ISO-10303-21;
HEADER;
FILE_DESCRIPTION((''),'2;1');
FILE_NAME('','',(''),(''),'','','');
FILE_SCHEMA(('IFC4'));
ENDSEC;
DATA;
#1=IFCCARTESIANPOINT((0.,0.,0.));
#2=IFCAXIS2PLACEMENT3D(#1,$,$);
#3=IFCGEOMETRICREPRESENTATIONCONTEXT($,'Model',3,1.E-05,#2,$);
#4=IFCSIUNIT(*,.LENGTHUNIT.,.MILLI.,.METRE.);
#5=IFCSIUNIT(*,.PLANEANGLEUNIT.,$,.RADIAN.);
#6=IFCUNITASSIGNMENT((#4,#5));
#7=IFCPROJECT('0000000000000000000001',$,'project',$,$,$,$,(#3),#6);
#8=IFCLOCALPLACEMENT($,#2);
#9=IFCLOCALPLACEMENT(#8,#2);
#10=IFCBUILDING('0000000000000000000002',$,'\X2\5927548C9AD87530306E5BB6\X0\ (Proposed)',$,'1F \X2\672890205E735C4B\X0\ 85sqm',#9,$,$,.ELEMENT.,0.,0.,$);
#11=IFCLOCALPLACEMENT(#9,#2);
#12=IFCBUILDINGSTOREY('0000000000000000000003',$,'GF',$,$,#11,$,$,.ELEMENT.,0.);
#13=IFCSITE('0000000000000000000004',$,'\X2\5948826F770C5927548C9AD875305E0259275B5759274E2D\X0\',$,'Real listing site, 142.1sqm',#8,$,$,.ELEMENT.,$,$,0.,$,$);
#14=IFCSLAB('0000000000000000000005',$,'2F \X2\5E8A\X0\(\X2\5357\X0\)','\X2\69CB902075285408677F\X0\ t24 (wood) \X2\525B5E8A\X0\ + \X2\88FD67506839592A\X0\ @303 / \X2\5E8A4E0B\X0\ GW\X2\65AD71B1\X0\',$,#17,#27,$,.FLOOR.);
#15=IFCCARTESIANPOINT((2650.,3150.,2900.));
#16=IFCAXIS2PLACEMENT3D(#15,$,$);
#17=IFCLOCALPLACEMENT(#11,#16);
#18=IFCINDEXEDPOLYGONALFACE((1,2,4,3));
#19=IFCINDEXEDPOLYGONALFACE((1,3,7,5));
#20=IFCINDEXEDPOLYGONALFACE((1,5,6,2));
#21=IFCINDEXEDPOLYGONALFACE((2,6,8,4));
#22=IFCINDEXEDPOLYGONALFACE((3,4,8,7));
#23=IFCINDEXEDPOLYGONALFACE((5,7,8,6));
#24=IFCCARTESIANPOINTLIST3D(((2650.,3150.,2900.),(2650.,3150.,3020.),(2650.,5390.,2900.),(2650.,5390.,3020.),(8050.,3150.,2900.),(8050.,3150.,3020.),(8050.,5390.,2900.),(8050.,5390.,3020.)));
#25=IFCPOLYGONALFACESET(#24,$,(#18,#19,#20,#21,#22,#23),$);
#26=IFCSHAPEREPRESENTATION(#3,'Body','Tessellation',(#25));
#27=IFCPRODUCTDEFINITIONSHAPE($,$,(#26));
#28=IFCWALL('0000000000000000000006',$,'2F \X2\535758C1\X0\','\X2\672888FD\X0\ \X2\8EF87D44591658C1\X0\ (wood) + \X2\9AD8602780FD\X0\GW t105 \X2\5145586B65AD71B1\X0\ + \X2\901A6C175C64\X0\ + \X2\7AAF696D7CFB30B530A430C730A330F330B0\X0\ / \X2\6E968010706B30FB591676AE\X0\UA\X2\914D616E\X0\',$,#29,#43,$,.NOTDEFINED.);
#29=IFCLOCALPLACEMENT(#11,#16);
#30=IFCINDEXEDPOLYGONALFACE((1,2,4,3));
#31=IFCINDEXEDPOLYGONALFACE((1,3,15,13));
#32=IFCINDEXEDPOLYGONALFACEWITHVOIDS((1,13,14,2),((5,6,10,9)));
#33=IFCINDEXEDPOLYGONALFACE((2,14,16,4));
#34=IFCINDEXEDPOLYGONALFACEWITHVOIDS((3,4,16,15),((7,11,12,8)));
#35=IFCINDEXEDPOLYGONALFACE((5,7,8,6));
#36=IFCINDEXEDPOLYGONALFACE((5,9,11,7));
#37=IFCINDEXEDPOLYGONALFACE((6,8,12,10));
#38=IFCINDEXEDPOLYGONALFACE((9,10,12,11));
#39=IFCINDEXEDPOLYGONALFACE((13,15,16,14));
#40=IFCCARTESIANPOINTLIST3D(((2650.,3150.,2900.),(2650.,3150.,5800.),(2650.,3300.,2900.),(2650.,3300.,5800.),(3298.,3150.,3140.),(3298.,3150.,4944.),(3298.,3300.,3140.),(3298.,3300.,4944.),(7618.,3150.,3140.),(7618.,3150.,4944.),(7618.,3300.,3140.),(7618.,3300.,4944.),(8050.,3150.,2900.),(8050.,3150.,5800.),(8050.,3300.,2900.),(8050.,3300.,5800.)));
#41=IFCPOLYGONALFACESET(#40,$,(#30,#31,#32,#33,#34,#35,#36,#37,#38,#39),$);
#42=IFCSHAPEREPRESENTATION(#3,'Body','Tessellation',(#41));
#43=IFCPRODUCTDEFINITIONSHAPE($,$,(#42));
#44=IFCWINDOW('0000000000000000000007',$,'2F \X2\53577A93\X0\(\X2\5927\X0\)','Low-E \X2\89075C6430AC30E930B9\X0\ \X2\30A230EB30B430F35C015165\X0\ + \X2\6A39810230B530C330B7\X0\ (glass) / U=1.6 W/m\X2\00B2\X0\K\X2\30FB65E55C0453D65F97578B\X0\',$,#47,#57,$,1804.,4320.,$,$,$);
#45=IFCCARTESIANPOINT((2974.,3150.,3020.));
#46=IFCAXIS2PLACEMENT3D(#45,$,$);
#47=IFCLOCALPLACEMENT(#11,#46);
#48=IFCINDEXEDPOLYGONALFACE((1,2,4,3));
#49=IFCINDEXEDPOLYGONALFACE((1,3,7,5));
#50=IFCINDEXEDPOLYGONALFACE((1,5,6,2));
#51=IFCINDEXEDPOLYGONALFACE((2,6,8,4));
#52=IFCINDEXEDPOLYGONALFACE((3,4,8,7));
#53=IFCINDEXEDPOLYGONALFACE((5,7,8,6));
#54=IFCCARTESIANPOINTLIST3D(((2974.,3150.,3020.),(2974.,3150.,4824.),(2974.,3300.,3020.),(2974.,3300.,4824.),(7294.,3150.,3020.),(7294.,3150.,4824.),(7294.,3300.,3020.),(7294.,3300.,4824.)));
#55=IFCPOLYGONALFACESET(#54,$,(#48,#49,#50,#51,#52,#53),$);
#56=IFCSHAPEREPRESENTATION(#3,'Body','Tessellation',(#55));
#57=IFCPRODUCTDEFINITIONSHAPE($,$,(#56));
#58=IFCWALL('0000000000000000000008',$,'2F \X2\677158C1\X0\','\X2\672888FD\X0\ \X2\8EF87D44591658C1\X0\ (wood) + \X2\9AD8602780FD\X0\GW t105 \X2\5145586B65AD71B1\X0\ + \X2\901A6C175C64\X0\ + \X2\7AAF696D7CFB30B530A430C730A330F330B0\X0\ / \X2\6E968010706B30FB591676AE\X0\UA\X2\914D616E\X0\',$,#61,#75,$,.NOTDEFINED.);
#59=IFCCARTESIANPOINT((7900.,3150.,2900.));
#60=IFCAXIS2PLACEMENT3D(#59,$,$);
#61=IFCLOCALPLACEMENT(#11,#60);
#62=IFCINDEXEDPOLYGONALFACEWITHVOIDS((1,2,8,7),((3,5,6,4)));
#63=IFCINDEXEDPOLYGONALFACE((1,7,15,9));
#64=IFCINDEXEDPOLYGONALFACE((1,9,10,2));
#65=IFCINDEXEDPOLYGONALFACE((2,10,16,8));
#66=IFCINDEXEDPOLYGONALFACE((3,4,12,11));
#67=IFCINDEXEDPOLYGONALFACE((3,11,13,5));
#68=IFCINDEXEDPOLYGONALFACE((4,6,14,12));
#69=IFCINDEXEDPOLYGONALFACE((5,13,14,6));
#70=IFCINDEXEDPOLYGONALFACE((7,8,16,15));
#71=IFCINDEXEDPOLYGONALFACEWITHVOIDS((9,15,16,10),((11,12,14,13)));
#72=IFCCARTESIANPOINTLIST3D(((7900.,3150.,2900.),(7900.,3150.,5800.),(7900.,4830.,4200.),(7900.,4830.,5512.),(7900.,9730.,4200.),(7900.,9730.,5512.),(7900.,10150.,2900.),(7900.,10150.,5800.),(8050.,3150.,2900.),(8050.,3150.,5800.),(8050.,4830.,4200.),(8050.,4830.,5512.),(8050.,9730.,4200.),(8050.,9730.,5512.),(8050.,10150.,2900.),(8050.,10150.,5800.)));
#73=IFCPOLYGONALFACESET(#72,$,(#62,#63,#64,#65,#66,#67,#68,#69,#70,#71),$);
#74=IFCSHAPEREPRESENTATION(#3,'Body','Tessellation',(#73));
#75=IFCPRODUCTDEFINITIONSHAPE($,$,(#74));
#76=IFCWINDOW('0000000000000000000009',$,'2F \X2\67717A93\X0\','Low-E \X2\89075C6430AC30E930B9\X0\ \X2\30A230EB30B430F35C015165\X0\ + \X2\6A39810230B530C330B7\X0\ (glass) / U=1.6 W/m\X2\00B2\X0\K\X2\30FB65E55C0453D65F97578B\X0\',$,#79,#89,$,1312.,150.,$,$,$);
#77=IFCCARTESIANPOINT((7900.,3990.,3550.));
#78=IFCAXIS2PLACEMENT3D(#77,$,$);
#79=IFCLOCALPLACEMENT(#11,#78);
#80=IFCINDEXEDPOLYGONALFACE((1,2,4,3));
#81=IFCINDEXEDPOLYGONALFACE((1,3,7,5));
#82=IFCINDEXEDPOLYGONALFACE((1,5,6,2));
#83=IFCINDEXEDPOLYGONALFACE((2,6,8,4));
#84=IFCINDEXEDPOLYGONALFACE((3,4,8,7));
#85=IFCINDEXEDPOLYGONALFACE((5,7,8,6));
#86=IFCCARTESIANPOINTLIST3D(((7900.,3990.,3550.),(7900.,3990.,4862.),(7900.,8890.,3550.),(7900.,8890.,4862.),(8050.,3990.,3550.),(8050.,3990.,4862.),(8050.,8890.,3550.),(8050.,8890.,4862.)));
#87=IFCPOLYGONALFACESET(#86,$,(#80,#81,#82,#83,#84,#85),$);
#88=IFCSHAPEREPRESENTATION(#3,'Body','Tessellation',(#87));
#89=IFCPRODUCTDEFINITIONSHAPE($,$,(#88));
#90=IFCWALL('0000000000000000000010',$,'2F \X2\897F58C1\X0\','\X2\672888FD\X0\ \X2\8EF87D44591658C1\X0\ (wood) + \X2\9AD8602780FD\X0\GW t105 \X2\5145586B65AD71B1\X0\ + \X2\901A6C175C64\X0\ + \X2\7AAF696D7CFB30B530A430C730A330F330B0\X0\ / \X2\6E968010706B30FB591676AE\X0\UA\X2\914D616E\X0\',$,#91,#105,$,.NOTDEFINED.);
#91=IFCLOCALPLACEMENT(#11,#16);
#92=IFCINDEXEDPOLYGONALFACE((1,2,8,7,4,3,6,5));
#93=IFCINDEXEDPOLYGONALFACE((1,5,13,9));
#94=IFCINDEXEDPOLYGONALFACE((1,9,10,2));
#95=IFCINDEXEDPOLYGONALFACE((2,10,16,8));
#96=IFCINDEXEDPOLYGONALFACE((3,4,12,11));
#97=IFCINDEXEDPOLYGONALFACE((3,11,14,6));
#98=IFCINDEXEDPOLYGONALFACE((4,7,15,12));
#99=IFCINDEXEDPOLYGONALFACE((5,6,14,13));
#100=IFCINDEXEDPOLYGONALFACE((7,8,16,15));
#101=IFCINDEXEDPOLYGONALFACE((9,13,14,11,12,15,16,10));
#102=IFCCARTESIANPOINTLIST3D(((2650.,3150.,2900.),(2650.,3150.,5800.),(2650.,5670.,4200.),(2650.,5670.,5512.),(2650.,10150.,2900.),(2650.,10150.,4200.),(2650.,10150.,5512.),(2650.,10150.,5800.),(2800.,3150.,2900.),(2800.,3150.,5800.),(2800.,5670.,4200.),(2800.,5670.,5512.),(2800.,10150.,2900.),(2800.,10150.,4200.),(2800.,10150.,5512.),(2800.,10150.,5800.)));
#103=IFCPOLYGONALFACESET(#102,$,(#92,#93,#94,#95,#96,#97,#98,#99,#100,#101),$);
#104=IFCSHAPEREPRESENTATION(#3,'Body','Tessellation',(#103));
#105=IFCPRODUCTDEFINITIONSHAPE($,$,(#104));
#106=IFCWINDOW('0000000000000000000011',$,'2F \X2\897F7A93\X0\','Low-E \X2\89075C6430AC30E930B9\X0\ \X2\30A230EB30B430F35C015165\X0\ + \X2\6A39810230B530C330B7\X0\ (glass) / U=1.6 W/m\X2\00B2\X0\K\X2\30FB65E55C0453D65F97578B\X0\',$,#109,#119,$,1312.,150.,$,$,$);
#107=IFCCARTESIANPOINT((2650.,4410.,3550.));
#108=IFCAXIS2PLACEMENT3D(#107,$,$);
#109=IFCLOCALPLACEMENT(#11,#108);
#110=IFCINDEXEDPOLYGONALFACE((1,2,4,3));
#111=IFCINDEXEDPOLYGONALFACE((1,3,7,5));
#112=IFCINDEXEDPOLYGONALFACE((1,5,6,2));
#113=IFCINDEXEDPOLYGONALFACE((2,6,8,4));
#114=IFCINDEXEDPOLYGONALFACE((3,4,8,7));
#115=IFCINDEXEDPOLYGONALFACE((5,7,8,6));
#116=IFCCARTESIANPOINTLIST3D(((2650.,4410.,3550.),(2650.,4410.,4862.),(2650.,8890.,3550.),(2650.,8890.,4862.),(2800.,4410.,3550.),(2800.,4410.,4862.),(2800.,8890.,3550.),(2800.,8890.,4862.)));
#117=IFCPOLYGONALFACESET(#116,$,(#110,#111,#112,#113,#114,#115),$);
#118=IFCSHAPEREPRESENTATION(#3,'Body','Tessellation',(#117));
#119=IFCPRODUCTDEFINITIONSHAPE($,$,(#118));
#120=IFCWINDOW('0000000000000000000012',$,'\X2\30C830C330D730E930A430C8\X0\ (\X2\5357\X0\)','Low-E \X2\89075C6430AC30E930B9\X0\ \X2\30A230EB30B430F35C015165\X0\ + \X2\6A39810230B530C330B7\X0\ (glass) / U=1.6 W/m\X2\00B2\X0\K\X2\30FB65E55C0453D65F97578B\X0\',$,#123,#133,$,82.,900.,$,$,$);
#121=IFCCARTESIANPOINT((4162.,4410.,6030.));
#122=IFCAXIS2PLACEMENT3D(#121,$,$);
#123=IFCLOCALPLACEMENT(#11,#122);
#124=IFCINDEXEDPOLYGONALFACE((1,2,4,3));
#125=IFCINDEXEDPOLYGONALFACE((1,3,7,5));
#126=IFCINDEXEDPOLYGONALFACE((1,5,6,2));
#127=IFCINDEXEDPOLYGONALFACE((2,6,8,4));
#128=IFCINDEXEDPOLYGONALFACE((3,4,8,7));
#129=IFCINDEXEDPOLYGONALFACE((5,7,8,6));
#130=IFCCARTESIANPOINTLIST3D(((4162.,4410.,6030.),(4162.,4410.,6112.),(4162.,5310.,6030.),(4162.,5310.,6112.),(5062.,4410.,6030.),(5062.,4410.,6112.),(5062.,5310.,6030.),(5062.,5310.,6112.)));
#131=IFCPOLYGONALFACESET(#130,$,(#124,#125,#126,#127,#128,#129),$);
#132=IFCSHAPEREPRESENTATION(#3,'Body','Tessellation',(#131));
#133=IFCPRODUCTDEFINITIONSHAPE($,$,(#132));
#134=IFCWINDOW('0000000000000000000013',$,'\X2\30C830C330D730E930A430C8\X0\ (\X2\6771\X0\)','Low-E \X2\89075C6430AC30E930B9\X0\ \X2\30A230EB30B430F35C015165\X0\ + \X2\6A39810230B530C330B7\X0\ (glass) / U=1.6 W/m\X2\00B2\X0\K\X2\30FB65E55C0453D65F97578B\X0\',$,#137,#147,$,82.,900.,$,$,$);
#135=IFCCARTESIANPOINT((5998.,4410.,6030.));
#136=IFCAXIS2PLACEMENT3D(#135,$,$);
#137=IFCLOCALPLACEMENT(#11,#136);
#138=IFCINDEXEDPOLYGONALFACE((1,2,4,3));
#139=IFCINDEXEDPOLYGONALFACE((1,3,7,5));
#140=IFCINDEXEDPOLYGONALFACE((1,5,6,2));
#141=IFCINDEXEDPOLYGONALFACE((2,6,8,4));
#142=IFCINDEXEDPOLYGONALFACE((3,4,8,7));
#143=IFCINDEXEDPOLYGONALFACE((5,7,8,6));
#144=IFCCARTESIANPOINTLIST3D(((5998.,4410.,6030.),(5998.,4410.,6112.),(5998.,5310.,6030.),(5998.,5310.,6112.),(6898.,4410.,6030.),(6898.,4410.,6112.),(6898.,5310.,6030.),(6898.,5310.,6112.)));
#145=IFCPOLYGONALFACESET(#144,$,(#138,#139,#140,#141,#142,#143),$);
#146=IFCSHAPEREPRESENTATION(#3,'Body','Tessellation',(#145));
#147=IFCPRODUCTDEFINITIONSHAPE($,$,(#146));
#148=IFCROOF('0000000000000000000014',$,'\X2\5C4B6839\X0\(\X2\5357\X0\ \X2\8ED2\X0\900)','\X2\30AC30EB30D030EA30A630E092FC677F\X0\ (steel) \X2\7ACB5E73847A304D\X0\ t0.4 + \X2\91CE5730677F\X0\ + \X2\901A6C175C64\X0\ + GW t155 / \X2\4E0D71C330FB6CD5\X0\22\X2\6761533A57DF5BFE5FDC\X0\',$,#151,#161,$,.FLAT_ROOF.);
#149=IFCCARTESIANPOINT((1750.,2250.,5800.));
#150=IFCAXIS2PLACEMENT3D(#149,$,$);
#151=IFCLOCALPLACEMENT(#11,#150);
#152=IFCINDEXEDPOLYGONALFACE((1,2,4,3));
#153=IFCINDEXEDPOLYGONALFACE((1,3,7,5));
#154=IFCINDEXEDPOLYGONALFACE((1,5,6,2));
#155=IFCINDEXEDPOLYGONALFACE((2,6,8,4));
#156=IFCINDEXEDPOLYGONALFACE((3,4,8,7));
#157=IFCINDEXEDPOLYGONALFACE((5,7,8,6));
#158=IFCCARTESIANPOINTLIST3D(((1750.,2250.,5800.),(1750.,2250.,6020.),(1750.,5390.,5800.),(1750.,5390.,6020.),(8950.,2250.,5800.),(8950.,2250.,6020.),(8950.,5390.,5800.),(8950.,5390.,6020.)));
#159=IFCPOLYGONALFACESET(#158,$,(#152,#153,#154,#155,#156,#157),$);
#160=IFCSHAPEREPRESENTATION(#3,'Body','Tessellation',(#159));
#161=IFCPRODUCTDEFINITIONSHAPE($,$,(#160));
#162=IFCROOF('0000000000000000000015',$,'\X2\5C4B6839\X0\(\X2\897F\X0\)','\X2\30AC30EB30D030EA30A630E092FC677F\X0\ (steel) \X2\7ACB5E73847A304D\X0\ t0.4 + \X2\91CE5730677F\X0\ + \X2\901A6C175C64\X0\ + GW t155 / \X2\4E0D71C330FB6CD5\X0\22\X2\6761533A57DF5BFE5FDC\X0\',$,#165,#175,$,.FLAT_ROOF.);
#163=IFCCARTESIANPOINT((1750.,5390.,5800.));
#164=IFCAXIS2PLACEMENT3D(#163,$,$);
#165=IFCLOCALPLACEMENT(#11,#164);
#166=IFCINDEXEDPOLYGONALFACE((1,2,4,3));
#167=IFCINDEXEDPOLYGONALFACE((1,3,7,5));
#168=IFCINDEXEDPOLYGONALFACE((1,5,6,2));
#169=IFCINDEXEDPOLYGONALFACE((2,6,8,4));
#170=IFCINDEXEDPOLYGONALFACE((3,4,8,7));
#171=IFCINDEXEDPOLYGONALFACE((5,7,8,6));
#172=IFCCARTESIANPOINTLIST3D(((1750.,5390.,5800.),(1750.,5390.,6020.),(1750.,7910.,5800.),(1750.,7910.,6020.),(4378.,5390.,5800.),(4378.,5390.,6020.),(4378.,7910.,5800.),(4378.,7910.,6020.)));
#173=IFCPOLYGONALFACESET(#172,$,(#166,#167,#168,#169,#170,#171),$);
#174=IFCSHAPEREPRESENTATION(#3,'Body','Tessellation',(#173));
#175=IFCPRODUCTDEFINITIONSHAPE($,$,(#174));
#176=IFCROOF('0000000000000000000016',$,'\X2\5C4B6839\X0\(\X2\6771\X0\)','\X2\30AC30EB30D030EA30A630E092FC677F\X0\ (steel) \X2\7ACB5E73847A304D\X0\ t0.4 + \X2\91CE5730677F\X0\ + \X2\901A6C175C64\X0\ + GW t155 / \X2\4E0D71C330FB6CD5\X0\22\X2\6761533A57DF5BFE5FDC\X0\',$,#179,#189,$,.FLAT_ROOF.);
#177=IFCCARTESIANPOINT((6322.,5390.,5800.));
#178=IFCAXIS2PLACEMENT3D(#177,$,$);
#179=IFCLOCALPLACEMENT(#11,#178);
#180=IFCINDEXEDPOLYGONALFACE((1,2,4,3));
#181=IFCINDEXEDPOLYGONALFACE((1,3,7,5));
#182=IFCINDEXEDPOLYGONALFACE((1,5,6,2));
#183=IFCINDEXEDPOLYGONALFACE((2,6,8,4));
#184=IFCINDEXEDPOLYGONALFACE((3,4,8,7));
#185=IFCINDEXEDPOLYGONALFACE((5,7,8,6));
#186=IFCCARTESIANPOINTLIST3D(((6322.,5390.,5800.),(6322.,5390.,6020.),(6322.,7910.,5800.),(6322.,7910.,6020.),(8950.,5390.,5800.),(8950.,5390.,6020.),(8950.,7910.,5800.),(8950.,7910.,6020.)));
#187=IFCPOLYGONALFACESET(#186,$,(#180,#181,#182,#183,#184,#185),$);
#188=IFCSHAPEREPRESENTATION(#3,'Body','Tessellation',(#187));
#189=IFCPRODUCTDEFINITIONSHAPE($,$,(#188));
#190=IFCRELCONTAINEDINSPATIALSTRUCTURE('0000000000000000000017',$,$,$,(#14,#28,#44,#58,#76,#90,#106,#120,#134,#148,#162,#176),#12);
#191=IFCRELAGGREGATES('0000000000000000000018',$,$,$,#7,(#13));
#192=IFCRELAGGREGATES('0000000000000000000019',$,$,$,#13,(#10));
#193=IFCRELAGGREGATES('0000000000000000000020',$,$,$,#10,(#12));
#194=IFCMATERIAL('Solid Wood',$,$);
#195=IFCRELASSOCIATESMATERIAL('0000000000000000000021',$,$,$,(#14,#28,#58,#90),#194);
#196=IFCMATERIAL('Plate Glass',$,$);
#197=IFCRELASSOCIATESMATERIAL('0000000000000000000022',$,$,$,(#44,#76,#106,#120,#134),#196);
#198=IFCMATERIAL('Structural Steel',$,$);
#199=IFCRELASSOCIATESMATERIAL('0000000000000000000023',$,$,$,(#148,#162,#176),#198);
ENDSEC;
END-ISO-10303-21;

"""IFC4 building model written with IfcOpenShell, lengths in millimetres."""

from ifc_helpers import new_model, si_unit, frame, frame_2d, origin, place, context, project, spatial, rectangle, extrude, material, element, fill, save


model = new_model("IFC4")

# Units and contexts
model_context = context("Model", 3, precision=1e-05, world=origin())
ifc_project = project(units=[si_unit("LENGTHUNIT", "METRE", prefix="MILLI"), si_unit("PLANEANGLEUNIT", "RADIAN")], contexts=[model_context])

# Site, building, storey
site_placement = place(None, origin())
site = spatial("IfcSite", under=ifc_project, at=site_placement, Name="奈良県大和高田市大字大中", ObjectType="Real listing site, 142.1sqm", CompositionType="ELEMENT", RefElevation=0.0)
building_placement = place(site_placement, origin())
building = spatial("IfcBuilding", under=site, at=building_placement, Name="大和高田の家 (Proposed)", ObjectType="1F 木造平屋 85sqm", CompositionType="ELEMENT", ElevationOfRefHeight=0.0, ElevationOfTerrain=0.0)
storey_placement = place(building_placement, origin())
storey = spatial("IfcBuildingStorey", under=building, at=storey_placement, Name="GF", CompositionType="ELEMENT", Elevation=0.0)

# Slab
ifc_material_1 = material(Name="Solid Wood")
slab_placement = place(storey_placement, frame((2650.0, 3150.0, 2900.0)))
element("IfcSlab", 1, at=slab_placement, inside=storey, material=ifc_material_1, Name="2F 床(南)", Description="構造用合板 t24 (wood) 剛床 + 製材根太 @303 / 床下 GW断熱", PredefinedType="FLOOR", context=model_context, shape_type="SweptSolid", body=[
    extrude(rectangle(XDim=5400.0, YDim=2240.0, at=frame_2d((2700.0, 1120.0))), frame((2650.0, 3150.0, 2900.0)), (0.0, 0.0, 1.0), 120.0),
])

# Walls, openings, windows
wall_1_placement = place(storey_placement, frame((2650.0, 3150.0, 2900.0)))
wall_1 = element("IfcWall", 2, at=wall_1_placement, inside=storey, material=ifc_material_1, Name="2F 南壁", Description="木製 軸組外壁 (wood) + 高性能GW t105 充填断熱 + 通気層 + 窯業系サイディング / 準耐火・外皮UA配慮", PredefinedType="NOTDEFINED", context=model_context, shape_type="SweptSolid", body=[
    extrude(rectangle(XDim=5400.0, YDim=150.0, at=frame_2d((2700.0, 75.0))), frame((2650.0, 3150.0, 2900.0)), (0.0, 0.0, 1.0), 2900.0),
])
opening_1_placement = place(storey_placement, frame((2974.0, 3150.0, 3020.0)))
opening_1 = element("IfcOpeningElement", 3, at=opening_1_placement, cuts=wall_1, PredefinedType="NOTDEFINED", context=model_context, shape_type="SweptSolid", body=[
    extrude(rectangle(XDim=4320.0, YDim=150.0, at=frame_2d((2160.0, 75.0))), frame((2974.0, 3150.0, 3020.0)), (0.0, 0.0, 1.0), 1804.0),
])
ifc_material_2 = material(Name="Plate Glass")
window_1_placement = place(storey_placement, frame((2974.0, 3150.0, 3020.0)))
window_1 = element("IfcWindow", 4, at=window_1_placement, inside=storey, material=ifc_material_2, Name="2F 南窓(大)", Description="Low-E 複層ガラス アルゴン封入 + 樹脂サッシ (glass) / U=1.6 W/m²K・日射取得型", OverallHeight=1804.0, OverallWidth=4320.0, context=model_context, shape_type="SweptSolid", body=[
    extrude(rectangle(XDim=4320.0, YDim=150.0, at=frame_2d((2160.0, 75.0))), frame((2974.0, 3150.0, 3020.0)), (0.0, 0.0, 1.0), 1804.0),
])
fill(opening_1, window_1)
wall_2_placement = place(storey_placement, frame((7900.0, 3150.0, 2900.0)))
wall_2 = element("IfcWall", 5, at=wall_2_placement, inside=storey, material=ifc_material_1, Name="2F 東壁", Description="木製 軸組外壁 (wood) + 高性能GW t105 充填断熱 + 通気層 + 窯業系サイディング / 準耐火・外皮UA配慮", PredefinedType="NOTDEFINED", context=model_context, shape_type="SweptSolid", body=[
    extrude(rectangle(XDim=150.0, YDim=7000.0, at=frame_2d((75.0, 3500.0))), frame((7900.0, 3150.0, 2900.0)), (0.0, 0.0, 1.0), 2900.0),
])
opening_2_placement = place(storey_placement, frame((7900.0, 3990.0, 3550.0)))
opening_2 = element("IfcOpeningElement", 6, at=opening_2_placement, cuts=wall_2, PredefinedType="NOTDEFINED", context=model_context, shape_type="SweptSolid", body=[
    extrude(rectangle(XDim=150.0, YDim=4900.0, at=frame_2d((75.0, 2450.0))), frame((7900.0, 3990.0, 3550.0)), (0.0, 0.0, 1.0), 1312.0),
])
window_2_placement = place(storey_placement, frame((7900.0, 3990.0, 3550.0)))
window_2 = element("IfcWindow", 7, at=window_2_placement, inside=storey, material=ifc_material_2, Name="2F 東窓", Description="Low-E 複層ガラス アルゴン封入 + 樹脂サッシ (glass) / U=1.6 W/m²K・日射取得型", OverallHeight=1312.0, OverallWidth=150.0, context=model_context, shape_type="SweptSolid", body=[
    extrude(rectangle(XDim=150.0, YDim=4900.0, at=frame_2d((75.0, 2450.0))), frame((7900.0, 3990.0, 3550.0)), (0.0, 0.0, 1.0), 1312.0),
])
fill(opening_2, window_2)
wall_3_placement = place(storey_placement, frame((2650.0, 3150.0, 2900.0)))
wall_3 = element("IfcWall", 8, at=wall_3_placement, inside=storey, material=ifc_material_1, Name="2F 西壁", Description="木製 軸組外壁 (wood) + 高性能GW t105 充填断熱 + 通気層 + 窯業系サイディング / 準耐火・外皮UA配慮", PredefinedType="NOTDEFINED", context=model_context, shape_type="SweptSolid", body=[
    extrude(rectangle(XDim=150.0, YDim=7000.0, at=frame_2d((75.0, 3500.0))), frame((2650.0, 3150.0, 2900.0)), (0.0, 0.0, 1.0), 2900.0),
])
opening_3_placement = place(storey_placement, frame((2650.0, 4410.0, 3550.0)))
opening_3 = element("IfcOpeningElement", 9, at=opening_3_placement, cuts=wall_3, PredefinedType="NOTDEFINED", context=model_context, shape_type="SweptSolid", body=[
    extrude(rectangle(XDim=150.0, YDim=4480.0, at=frame_2d((75.0, 2240.0))), frame((2650.0, 4410.0, 3550.0)), (0.0, 0.0, 1.0), 1312.0),
])
window_3_placement = place(storey_placement, frame((2650.0, 4410.0, 3550.0)))
window_3 = element("IfcWindow", 10, at=window_3_placement, inside=storey, material=ifc_material_2, Name="2F 西窓", Description="Low-E 複層ガラス アルゴン封入 + 樹脂サッシ (glass) / U=1.6 W/m²K・日射取得型", OverallHeight=1312.0, OverallWidth=150.0, context=model_context, shape_type="SweptSolid", body=[
    extrude(rectangle(XDim=150.0, YDim=4480.0, at=frame_2d((75.0, 2240.0))), frame((2650.0, 4410.0, 3550.0)), (0.0, 0.0, 1.0), 1312.0),
])
fill(opening_3, window_3)

# Windows
window_4_placement = place(storey_placement, frame((4162.0, 4410.0, 6030.0)))
element("IfcWindow", 11, at=window_4_placement, inside=storey, material=ifc_material_2, Name="トップライト (南)", Description="Low-E 複層ガラス アルゴン封入 + 樹脂サッシ (glass) / U=1.6 W/m²K・日射取得型", OverallHeight=82.0, OverallWidth=900.0, context=model_context, shape_type="SweptSolid", body=[
    extrude(rectangle(XDim=900.0, YDim=900.0, at=frame_2d((450.0, 450.0))), frame((4162.0, 4410.0, 6030.0)), (0.0, 0.0, 1.0), 82.0),
])
window_5_placement = place(storey_placement, frame((5998.0, 4410.0, 6030.0)))
element("IfcWindow", 12, at=window_5_placement, inside=storey, material=ifc_material_2, Name="トップライト (東)", Description="Low-E 複層ガラス アルゴン封入 + 樹脂サッシ (glass) / U=1.6 W/m²K・日射取得型", OverallHeight=82.0, OverallWidth=900.0, context=model_context, shape_type="SweptSolid", body=[
    extrude(rectangle(XDim=900.0, YDim=900.0, at=frame_2d((450.0, 450.0))), frame((5998.0, 4410.0, 6030.0)), (0.0, 0.0, 1.0), 82.0),
])

# Roofs
ifc_material_3 = material(Name="Structural Steel")
roof_1_placement = place(storey_placement, frame((1750.0, 2250.0, 5800.0)))
element("IfcRoof", 13, at=roof_1_placement, inside=storey, material=ifc_material_3, Name="屋根(南 軒900)", Description="ガルバリウム鋼板 (steel) 立平葺き t0.4 + 野地板 + 通気層 + GW t155 / 不燃・法22条区域対応", PredefinedType="FLAT_ROOF", context=model_context, shape_type="SweptSolid", body=[
    extrude(rectangle(XDim=7200.0, YDim=3140.0, at=frame_2d((3600.0, 1570.0))), frame((1750.0, 2250.0, 5800.0)), (0.0, 0.0, 1.0), 220.0),
])
roof_2_placement = place(storey_placement, frame((1750.0, 5390.0, 5800.0)))
element("IfcRoof", 14, at=roof_2_placement, inside=storey, material=ifc_material_3, Name="屋根(西)", Description="ガルバリウム鋼板 (steel) 立平葺き t0.4 + 野地板 + 通気層 + GW t155 / 不燃・法22条区域対応", PredefinedType="FLAT_ROOF", context=model_context, shape_type="SweptSolid", body=[
    extrude(rectangle(XDim=2628.0, YDim=2520.0, at=frame_2d((1314.0, 1260.0))), frame((1750.0, 5390.0, 5800.0)), (0.0, 0.0, 1.0), 220.0),
])
roof_3_placement = place(storey_placement, frame((6322.0, 5390.0, 5800.0)))
element("IfcRoof", 15, at=roof_3_placement, inside=storey, material=ifc_material_3, Name="屋根(東)", Description="ガルバリウム鋼板 (steel) 立平葺き t0.4 + 野地板 + 通気層 + GW t155 / 不燃・法22条区域対応", PredefinedType="FLAT_ROOF", context=model_context, shape_type="SweptSolid", body=[
    extrude(rectangle(XDim=2628.0, YDim=2520.0, at=frame_2d((1314.0, 1260.0))), frame((6322.0, 5390.0, 5800.0)), (0.0, 0.0, 1.0), 220.0),
])

save(model, "model.ifc")
